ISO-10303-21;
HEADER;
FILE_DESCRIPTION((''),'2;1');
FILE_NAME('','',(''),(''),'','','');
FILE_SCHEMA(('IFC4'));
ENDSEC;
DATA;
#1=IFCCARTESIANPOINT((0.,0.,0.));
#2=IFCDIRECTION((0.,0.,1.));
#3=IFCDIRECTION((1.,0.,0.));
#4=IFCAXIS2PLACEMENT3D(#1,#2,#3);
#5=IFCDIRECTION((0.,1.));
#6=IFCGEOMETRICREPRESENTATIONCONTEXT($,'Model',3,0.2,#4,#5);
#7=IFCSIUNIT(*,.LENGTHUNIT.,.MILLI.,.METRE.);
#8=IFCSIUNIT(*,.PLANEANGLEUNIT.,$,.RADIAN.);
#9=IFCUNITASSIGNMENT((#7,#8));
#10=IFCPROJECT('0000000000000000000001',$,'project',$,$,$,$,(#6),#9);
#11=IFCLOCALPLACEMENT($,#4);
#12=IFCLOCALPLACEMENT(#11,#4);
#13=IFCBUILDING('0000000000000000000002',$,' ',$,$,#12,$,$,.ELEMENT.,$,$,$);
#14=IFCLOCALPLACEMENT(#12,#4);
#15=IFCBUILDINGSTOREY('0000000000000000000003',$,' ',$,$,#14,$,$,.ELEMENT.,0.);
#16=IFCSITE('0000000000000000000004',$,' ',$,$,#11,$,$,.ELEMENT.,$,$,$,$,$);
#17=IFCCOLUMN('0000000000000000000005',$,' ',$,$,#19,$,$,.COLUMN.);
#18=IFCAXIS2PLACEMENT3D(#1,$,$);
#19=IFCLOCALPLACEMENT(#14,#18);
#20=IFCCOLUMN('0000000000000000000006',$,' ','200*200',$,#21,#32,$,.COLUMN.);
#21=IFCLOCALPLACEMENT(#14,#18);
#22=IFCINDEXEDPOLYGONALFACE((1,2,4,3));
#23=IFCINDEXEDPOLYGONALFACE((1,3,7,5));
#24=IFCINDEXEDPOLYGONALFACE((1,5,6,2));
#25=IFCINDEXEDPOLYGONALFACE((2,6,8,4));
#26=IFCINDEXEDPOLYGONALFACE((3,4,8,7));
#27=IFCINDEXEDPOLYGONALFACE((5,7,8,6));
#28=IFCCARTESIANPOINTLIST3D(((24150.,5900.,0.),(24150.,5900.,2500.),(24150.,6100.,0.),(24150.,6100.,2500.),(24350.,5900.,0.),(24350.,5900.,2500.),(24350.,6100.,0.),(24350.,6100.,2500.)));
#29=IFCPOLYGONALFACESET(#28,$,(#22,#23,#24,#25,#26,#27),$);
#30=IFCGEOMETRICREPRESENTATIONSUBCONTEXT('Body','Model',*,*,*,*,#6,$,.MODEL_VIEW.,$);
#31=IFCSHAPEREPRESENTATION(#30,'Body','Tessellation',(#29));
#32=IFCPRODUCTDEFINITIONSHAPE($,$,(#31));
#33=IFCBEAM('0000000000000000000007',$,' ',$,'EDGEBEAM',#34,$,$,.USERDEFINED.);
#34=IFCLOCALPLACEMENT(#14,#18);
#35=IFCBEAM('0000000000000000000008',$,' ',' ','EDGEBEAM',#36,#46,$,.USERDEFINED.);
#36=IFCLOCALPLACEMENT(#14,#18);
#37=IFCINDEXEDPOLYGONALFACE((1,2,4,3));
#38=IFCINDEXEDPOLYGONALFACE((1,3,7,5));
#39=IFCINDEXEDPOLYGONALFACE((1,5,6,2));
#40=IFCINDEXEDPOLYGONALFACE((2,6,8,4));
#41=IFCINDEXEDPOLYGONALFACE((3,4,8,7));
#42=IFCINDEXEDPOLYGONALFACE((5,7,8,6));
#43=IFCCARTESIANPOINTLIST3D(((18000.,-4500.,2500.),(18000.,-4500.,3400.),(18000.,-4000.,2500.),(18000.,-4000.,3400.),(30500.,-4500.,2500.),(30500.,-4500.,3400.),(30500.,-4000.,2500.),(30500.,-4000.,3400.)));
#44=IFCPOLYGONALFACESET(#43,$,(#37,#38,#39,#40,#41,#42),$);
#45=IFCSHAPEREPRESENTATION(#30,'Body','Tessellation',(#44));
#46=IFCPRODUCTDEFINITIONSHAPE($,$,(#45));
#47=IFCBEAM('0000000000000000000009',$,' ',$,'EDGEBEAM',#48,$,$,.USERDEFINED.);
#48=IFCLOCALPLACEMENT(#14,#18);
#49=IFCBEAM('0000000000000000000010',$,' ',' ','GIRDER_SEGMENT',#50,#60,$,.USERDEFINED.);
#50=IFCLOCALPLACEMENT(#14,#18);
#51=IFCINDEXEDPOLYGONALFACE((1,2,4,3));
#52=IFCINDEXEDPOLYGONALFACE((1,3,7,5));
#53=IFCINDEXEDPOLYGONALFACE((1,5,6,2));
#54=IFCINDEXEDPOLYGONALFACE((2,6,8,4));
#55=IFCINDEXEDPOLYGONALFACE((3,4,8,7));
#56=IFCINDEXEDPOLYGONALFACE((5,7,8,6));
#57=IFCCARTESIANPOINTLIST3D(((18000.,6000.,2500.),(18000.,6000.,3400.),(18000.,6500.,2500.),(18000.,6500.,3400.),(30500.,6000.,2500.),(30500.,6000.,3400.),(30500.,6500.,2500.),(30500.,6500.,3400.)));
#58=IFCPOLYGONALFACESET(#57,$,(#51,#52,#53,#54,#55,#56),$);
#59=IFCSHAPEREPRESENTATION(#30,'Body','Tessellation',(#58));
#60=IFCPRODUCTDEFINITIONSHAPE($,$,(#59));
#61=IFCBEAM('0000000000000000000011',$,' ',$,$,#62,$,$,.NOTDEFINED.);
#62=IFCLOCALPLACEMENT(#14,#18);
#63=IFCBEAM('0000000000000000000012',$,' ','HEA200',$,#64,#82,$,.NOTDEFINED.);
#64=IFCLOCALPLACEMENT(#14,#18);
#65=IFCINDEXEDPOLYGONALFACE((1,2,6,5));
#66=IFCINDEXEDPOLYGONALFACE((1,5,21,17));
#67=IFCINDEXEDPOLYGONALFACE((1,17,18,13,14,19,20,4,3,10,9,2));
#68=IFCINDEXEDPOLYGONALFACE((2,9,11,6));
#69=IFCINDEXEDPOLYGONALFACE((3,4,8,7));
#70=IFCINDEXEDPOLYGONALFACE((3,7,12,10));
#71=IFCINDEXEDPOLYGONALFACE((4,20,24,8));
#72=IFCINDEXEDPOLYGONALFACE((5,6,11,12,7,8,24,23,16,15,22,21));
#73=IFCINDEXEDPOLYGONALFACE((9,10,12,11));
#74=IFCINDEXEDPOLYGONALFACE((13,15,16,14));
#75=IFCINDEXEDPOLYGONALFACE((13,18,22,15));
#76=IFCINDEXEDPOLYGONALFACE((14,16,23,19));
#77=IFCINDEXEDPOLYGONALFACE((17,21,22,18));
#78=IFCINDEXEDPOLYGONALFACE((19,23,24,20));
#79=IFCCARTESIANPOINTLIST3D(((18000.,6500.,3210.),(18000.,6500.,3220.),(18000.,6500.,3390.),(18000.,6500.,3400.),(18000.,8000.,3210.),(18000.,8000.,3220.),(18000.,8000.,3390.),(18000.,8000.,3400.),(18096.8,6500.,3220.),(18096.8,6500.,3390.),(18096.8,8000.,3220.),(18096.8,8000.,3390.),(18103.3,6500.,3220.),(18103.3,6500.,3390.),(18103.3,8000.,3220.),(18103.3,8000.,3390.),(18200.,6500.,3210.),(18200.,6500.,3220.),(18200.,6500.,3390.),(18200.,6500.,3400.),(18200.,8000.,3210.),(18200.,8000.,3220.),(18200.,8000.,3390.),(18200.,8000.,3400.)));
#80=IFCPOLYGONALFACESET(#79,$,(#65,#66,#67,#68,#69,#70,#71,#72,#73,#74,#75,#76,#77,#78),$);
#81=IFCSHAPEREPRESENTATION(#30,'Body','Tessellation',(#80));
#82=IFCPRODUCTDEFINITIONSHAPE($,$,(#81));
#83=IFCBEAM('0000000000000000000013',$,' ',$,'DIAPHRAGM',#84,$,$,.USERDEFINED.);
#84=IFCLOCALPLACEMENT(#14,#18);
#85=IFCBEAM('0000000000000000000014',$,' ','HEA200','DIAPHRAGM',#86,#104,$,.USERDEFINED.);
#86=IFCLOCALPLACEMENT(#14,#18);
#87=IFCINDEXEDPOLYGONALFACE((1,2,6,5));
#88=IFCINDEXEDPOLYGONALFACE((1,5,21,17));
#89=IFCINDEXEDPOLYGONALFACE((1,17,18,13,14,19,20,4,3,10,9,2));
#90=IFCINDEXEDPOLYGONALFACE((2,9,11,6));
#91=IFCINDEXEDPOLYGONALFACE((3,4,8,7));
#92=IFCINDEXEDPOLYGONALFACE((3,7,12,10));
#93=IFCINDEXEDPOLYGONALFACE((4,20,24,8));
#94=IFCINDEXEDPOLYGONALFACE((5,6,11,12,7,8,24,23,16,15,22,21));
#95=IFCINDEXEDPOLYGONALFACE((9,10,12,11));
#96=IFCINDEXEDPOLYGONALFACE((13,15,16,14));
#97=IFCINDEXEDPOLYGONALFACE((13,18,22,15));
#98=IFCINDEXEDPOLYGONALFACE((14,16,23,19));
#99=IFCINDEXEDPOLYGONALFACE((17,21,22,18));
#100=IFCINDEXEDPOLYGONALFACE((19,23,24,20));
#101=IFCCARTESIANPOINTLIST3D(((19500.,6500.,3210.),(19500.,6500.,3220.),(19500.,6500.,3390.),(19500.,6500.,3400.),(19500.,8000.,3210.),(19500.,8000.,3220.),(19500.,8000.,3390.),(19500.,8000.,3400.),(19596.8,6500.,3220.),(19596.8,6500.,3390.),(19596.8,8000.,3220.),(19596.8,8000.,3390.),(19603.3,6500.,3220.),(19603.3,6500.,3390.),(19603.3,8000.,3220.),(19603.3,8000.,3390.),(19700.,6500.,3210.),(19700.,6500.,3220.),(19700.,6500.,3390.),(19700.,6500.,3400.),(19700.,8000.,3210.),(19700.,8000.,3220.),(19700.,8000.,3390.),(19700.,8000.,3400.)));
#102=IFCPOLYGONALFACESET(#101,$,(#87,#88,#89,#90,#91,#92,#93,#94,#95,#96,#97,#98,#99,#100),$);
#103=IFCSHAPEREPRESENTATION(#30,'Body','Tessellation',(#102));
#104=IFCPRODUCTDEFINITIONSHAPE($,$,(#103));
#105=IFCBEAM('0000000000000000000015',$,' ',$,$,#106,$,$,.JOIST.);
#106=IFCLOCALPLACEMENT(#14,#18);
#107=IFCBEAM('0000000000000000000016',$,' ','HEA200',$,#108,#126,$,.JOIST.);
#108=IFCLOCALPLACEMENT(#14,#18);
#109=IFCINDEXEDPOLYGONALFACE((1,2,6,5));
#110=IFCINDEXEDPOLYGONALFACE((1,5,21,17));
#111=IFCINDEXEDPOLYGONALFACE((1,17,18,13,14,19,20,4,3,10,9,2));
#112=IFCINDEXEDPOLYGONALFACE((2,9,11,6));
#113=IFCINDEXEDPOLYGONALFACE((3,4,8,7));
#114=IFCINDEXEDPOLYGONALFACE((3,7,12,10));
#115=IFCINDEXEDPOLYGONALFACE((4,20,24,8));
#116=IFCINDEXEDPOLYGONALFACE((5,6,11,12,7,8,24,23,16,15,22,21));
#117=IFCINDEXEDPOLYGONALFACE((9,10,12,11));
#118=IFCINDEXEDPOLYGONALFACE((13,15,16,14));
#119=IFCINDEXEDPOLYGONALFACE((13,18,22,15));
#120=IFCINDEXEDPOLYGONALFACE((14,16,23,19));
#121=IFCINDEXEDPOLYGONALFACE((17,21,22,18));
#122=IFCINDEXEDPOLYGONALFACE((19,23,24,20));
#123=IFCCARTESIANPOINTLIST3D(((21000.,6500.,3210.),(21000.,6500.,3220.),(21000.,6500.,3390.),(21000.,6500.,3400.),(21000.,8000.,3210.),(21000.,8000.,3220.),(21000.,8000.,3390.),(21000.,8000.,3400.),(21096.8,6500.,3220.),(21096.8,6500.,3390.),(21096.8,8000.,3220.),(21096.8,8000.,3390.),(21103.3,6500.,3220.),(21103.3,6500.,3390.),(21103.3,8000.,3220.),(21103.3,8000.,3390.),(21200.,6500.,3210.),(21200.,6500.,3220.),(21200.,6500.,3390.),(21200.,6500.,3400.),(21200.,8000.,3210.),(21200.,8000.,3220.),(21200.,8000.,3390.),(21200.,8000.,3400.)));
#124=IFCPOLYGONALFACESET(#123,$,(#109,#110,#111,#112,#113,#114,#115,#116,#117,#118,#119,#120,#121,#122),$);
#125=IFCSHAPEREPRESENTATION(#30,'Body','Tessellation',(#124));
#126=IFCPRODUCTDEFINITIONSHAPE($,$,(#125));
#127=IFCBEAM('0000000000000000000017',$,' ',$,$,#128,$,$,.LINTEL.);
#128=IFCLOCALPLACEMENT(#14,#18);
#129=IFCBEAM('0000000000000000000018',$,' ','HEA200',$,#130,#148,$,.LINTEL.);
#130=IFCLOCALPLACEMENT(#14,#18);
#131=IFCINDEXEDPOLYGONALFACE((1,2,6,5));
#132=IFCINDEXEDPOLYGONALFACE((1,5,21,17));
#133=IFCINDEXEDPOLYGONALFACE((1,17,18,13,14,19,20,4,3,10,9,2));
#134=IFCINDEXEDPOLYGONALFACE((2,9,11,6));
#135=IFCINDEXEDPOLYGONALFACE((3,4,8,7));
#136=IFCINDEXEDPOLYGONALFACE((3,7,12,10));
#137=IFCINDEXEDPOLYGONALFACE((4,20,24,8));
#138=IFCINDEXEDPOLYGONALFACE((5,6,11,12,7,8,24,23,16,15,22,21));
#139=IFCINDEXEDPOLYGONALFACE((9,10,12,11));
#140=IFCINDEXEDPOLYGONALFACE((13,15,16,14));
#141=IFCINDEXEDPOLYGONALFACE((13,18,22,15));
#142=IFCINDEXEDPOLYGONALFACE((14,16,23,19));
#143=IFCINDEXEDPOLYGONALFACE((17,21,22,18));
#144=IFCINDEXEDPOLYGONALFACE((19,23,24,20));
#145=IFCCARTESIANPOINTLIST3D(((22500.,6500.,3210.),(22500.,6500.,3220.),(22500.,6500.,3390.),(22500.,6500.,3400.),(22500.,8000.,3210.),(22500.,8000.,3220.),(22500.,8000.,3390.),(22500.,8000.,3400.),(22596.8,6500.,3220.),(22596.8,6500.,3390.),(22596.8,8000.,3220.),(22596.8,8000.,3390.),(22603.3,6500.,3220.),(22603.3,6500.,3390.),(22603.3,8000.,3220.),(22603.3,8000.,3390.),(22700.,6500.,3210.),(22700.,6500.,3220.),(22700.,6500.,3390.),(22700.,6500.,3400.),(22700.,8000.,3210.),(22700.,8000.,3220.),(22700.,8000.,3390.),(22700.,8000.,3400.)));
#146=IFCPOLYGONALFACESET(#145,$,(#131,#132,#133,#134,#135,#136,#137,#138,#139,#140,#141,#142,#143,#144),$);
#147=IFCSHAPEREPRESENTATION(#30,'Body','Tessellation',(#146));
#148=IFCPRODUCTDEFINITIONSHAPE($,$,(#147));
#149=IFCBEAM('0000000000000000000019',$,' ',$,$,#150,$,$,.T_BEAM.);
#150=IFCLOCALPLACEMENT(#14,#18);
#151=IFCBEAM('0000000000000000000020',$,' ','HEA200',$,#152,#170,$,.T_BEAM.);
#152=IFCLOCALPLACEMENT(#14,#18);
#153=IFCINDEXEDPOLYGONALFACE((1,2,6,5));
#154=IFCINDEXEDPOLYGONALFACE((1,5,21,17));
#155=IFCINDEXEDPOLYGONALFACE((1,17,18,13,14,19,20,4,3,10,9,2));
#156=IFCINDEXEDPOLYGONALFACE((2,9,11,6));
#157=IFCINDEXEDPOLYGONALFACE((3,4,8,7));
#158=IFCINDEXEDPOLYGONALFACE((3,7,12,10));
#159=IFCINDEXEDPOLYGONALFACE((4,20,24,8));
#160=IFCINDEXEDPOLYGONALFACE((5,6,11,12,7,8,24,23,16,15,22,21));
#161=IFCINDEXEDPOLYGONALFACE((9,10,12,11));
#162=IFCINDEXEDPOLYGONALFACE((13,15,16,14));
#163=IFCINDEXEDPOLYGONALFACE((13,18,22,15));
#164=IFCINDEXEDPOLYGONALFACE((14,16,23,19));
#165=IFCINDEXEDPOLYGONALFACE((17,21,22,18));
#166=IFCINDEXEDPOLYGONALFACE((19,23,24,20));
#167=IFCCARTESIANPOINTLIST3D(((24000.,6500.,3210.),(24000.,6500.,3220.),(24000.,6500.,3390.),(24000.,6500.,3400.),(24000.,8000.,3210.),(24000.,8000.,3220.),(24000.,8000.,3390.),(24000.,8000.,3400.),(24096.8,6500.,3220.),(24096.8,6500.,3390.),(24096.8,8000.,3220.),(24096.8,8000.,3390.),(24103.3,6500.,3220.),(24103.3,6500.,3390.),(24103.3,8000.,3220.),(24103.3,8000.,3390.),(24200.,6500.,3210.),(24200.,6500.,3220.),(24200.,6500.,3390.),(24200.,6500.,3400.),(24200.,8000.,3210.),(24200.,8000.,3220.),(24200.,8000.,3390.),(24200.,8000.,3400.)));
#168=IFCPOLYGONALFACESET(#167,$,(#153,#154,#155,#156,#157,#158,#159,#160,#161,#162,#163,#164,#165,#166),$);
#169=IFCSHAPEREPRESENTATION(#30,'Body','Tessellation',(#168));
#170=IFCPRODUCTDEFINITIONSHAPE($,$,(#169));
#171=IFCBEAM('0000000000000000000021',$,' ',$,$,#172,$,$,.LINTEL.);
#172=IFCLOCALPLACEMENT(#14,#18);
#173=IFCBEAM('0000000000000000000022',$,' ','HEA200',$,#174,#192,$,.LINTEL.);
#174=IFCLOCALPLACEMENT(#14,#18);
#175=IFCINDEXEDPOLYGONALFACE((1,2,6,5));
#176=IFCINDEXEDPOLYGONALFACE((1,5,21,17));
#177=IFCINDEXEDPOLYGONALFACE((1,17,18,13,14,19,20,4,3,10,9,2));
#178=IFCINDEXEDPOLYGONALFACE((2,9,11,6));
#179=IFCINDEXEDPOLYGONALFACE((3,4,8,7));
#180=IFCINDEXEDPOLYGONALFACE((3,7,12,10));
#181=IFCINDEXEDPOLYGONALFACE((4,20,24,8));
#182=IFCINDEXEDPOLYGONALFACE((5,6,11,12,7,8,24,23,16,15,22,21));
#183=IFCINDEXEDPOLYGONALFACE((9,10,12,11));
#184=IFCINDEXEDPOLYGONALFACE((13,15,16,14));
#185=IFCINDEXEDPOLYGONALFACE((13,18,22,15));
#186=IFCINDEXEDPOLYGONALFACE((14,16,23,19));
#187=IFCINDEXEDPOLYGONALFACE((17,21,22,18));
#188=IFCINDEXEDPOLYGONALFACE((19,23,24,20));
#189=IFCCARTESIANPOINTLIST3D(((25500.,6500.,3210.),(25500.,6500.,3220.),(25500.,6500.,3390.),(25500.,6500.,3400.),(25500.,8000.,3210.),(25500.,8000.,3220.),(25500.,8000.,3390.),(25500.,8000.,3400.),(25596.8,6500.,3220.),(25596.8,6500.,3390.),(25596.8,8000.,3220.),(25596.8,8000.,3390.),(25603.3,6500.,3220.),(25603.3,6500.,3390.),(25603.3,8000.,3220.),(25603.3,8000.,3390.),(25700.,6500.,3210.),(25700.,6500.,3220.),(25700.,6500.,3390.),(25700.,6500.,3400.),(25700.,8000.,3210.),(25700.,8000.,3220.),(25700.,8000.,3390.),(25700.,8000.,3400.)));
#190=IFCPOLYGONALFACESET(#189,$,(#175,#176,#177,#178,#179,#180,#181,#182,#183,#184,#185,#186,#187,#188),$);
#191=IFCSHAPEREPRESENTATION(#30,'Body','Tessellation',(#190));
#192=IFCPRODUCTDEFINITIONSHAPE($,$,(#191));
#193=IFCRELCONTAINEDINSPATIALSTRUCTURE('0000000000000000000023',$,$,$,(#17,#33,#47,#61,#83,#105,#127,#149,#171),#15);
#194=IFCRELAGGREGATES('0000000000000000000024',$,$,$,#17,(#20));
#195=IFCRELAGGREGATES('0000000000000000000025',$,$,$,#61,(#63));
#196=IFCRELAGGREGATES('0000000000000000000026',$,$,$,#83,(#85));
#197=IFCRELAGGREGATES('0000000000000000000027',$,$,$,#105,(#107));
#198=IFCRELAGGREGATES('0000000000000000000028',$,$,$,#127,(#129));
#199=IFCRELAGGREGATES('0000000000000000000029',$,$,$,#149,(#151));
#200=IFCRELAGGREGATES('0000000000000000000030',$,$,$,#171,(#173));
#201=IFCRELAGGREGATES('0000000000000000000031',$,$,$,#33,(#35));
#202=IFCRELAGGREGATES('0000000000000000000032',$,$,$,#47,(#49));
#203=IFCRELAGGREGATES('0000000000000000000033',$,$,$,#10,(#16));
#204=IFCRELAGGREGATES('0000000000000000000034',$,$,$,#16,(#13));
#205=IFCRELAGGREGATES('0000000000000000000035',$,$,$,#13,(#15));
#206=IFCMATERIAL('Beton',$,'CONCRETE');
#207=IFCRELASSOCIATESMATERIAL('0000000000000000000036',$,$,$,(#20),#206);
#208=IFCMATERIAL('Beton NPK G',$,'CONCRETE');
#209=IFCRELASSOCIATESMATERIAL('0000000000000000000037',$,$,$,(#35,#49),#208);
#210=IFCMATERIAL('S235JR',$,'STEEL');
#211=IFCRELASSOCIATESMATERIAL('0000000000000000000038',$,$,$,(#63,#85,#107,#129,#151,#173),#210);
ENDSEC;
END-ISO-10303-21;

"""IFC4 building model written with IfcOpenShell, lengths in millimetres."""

from ifc_helpers import new_model, si_unit, direction, frame, origin_with_axes, place, context, subcontext, project, spatial, line, indexed_curve, outline, extrude, material, element, aggregate, save


model = new_model("IFC4")

# Units and contexts
model_context = context("Model", 3, precision=0.2, world=origin_with_axes(), true_north=direction((0.0, 1.0)))
body_context = subcontext(model_context, "Body", "Model", "MODEL_VIEW")
ifc_project = project(units=[si_unit("LENGTHUNIT", "METRE", prefix="MILLI"), si_unit("PLANEANGLEUNIT", "RADIAN")], contexts=[model_context])

# Site, building, storey
site_placement = place(None, origin_with_axes())
site = spatial("IfcSite", under=ifc_project, at=site_placement, Name=" ", CompositionType="ELEMENT")
building_placement = place(site_placement, origin_with_axes())
building = spatial("IfcBuilding", under=site, at=building_placement, Name=" ", CompositionType="ELEMENT")
storey_placement = place(building_placement, origin_with_axes())
storey = spatial("IfcBuildingStorey", under=building, at=storey_placement, Name=" ", CompositionType="ELEMENT", Elevation=0.0)

# Columns
column_1_placement = place(storey_placement, frame((24250.0, 6000.0, 0.0), z_axis=(-1.0, 0.0, 0.0), x_axis=(0.0, 0.0, 1.0)))
column_1 = element("IfcColumn", 1, at=column_1_placement, inside=storey, Name=" ", PredefinedType="COLUMN")
ifc_material_1 = material(Name="Beton", Category="CONCRETE")
column_2_placement = place(column_1_placement, origin_with_axes())
column_2 = element("IfcColumn", 2, at=column_2_placement, material=ifc_material_1, Name=" ", Description="200*200", PredefinedType="COLUMN", context=body_context, shape_type="SolidModel", body=[
    extrude(outline(indexed_curve([(-100.0, -100.0), (100.0, -100.0), (100.0, 100.0), (-100.0, 100.0)], segments=[line(1, 2, 3, 4, 1)])), frame((0.0, 0.0, 0.0), z_axis=(-1.0, 0.0, 0.0), x_axis=(0.0, 0.0, 1.0)), (0.0, 0.0, -1.0), 2500.0),
])
aggregate(column_1, [column_2])

# Beams
beam_1_placement = place(storey_placement, frame((30500.0, -4250.0, 2950.0), z_axis=(0.0, 1.0, 0.0), x_axis=(-1.0, 0.0, 0.0)))
beam_1 = element("IfcBeam", 3, at=beam_1_placement, inside=storey, Name=" ", ObjectType="EDGEBEAM", PredefinedType="USERDEFINED")
ifc_material_2 = material(Name="Beton NPK G", Category="CONCRETE")
beam_2_placement = place(beam_1_placement, origin_with_axes())
beam_2 = element("IfcBeam", 4, at=beam_2_placement, material=ifc_material_2, Name=" ", Description=" ", ObjectType="EDGEBEAM", PredefinedType="USERDEFINED", context=body_context, shape_type="SolidModel", body=[
    extrude(outline(indexed_curve([(-250.0, -450.0), (250.0, -450.0), (250.0, 450.0), (-250.0, 450.0)], segments=[line(1, 2, 3, 4, 1)])), frame((0.0, 0.0, 0.0), z_axis=(-1.0, 0.0, 0.0), x_axis=(0.0, 0.0, 1.0)), (0.0, 0.0, -1.0), 12500.0),
])
beam_3_placement = place(storey_placement, frame((30500.0, 6250.0, 2950.0), z_axis=(0.0, 1.0, 0.0), x_axis=(-1.0, 0.0, 0.0)))
beam_3 = element("IfcBeam", 5, at=beam_3_placement, inside=storey, Name=" ", ObjectType="EDGEBEAM", PredefinedType="USERDEFINED")
beam_4_placement = place(beam_3_placement, origin_with_axes())
beam_4 = element("IfcBeam", 6, at=beam_4_placement, material=ifc_material_2, Name=" ", Description=" ", ObjectType="GIRDER_SEGMENT", PredefinedType="USERDEFINED", context=body_context, shape_type="SolidModel", body=[
    extrude(outline(indexed_curve([(-250.0, -450.0), (250.0, -450.0), (250.0, 450.0), (-250.0, 450.0)], segments=[line(1, 2, 3, 4, 1)])), frame((0.0, 0.0, 0.0), z_axis=(-1.0, 0.0, 0.0), x_axis=(0.0, 0.0, 1.0)), (0.0, 0.0, -1.0), 12500.0),
])
beam_5_placement = place(storey_placement, frame((18100.0, 6500.0, 3305.0), z_axis=(1.0, 0.0, 0.0), x_axis=(0.0, 1.0, 0.0)))
beam_5 = element("IfcBeam", 7, at=beam_5_placement, inside=storey, Name=" ", PredefinedType="NOTDEFINED")
ifc_material_3 = material(Name="S235JR", Category="STEEL")
beam_6_placement = place(beam_5_placement, origin_with_axes())
beam_6 = element("IfcBeam", 8, at=beam_6_placement, material=ifc_material_3, Name=" ", Description="HEA200", PredefinedType="NOTDEFINED", context=body_context, shape_type="SolidModel", body=[
    extrude(outline(indexed_curve([(-100.0, -95.0), (100.0, -95.0), (100.0, -85.0), (3.2, -85.0), (3.2, 85.0), (100.0, 85.0), (100.0, 95.0), (-100.0, 95.0), (-100.0, 85.0), (-3.2, 85.0), (-3.2, -85.0), (-100.0, -85.0)], segments=[line(1, 2, 3, 4, 5, 6, 7, 8, 9, 10, 11, 12, 1)])), frame((0.0, 0.0, 0.0), z_axis=(-1.0, 0.0, 0.0), x_axis=(0.0, 0.0, 1.0)), (0.0, 0.0, -1.0), 1500.0),
])
aggregate(beam_5, [beam_6])
beam_7_placement = place(storey_placement, frame((19600.0, 6500.0, 3305.0), z_axis=(1.0, 0.0, 0.0), x_axis=(0.0, 1.0, 0.0)))
beam_7 = element("IfcBeam", 9, at=beam_7_placement, inside=storey, Name=" ", ObjectType="DIAPHRAGM", PredefinedType="USERDEFINED")
beam_8_placement = place(beam_7_placement, origin_with_axes())
beam_8 = element("IfcBeam", 10, at=beam_8_placement, material=ifc_material_3, Name=" ", Description="HEA200", ObjectType="DIAPHRAGM", PredefinedType="USERDEFINED", context=body_context, shape_type="SolidModel", body=[
    extrude(outline(indexed_curve([(-100.0, -95.0), (100.0, -95.0), (100.0, -85.0), (3.2, -85.0), (3.2, 85.0), (100.0, 85.0), (100.0, 95.0), (-100.0, 95.0), (-100.0, 85.0), (-3.2, 85.0), (-3.2, -85.0), (-100.0, -85.0)], segments=[line(1, 2, 3, 4, 5, 6, 7, 8, 9, 10, 11, 12, 1)])), frame((0.0, 0.0, 0.0), z_axis=(-1.0, 0.0, 0.0), x_axis=(0.0, 0.0, 1.0)), (0.0, 0.0, -1.0), 1500.0),
])
aggregate(beam_7, [beam_8])
beam_9_placement = place(storey_placement, frame((21100.0, 6500.0, 3305.0), z_axis=(1.0, 0.0, 0.0), x_axis=(0.0, 1.0, 0.0)))
beam_9 = element("IfcBeam", 11, at=beam_9_placement, inside=storey, Name=" ", PredefinedType="JOIST")
beam_10_placement = place(beam_9_placement, origin_with_axes())
beam_10 = element("IfcBeam", 12, at=beam_10_placement, material=ifc_material_3, Name=" ", Description="HEA200", PredefinedType="JOIST", context=body_context, shape_type="SolidModel", body=[
    extrude(outline(indexed_curve([(-100.0, -95.0), (100.0, -95.0), (100.0, -85.0), (3.2, -85.0), (3.2, 85.0), (100.0, 85.0), (100.0, 95.0), (-100.0, 95.0), (-100.0, 85.0), (-3.2, 85.0), (-3.2, -85.0), (-100.0, -85.0)], segments=[line(1, 2, 3, 4, 5, 6, 7, 8, 9, 10, 11, 12, 1)])), frame((0.0, 0.0, 0.0), z_axis=(-1.0, 0.0, 0.0), x_axis=(0.0, 0.0, 1.0)), (0.0, 0.0, -1.0), 1500.0),
])
aggregate(beam_9, [beam_10])
beam_11_placement = place(storey_placement, frame((22600.0, 6500.0, 3305.0), z_axis=(1.0, 0.0, 0.0), x_axis=(0.0, 1.0, 0.0)))
beam_11 = element("IfcBeam", 13, at=beam_11_placement, inside=storey, Name=" ", PredefinedType="LINTEL")
beam_12_placement = place(beam_11_placement, origin_with_axes())
beam_12 = element("IfcBeam", 14, at=beam_12_placement, material=ifc_material_3, Name=" ", Description="HEA200", PredefinedType="LINTEL", context=body_context, shape_type="SolidModel", body=[
    extrude(outline(indexed_curve([(-100.0, -95.0), (100.0, -95.0), (100.0, -85.0), (3.2, -85.0), (3.2, 85.0), (100.0, 85.0), (100.0, 95.0), (-100.0, 95.0), (-100.0, 85.0), (-3.2, 85.0), (-3.2, -85.0), (-100.0, -85.0)], segments=[line(1, 2, 3, 4, 5, 6, 7, 8, 9, 10, 11, 12, 1)])), frame((0.0, 0.0, 0.0), z_axis=(-1.0, 0.0, 0.0), x_axis=(0.0, 0.0, 1.0)), (0.0, 0.0, -1.0), 1500.0),
])
aggregate(beam_11, [beam_12])
beam_13_placement = place(storey_placement, frame((24100.0, 6500.0, 3305.0), z_axis=(1.0, 0.0, 0.0), x_axis=(0.0, 1.0, 0.0)))
beam_13 = element("IfcBeam", 15, at=beam_13_placement, inside=storey, Name=" ", PredefinedType="T_BEAM")
beam_14_placement = place(beam_13_placement, origin_with_axes())
beam_14 = element("IfcBeam", 16, at=beam_14_placement, material=ifc_material_3, Name=" ", Description="HEA200", PredefinedType="T_BEAM", context=body_context, shape_type="SolidModel", body=[
    extrude(outline(indexed_curve([(-100.0, -95.0), (100.0, -95.0), (100.0, -85.0), (3.2, -85.0), (3.2, 85.0), (100.0, 85.0), (100.0, 95.0), (-100.0, 95.0), (-100.0, 85.0), (-3.2, 85.0), (-3.2, -85.0), (-100.0, -85.0)], segments=[line(1, 2, 3, 4, 5, 6, 7, 8, 9, 10, 11, 12, 1)])), frame((0.0, 0.0, 0.0), z_axis=(-1.0, 0.0, 0.0), x_axis=(0.0, 0.0, 1.0)), (0.0, 0.0, -1.0), 1500.0),
])
aggregate(beam_13, [beam_14])
beam_15_placement = place(storey_placement, frame((25600.0, 6500.0, 3305.0), z_axis=(1.0, 0.0, 0.0), x_axis=(0.0, 1.0, 0.0)))
beam_15 = element("IfcBeam", 17, at=beam_15_placement, inside=storey, Name=" ", PredefinedType="LINTEL")
beam_16_placement = place(beam_15_placement, origin_with_axes())
beam_16 = element("IfcBeam", 18, at=beam_16_placement, material=ifc_material_3, Name=" ", Description="HEA200", PredefinedType="LINTEL", context=body_context, shape_type="SolidModel", body=[
    extrude(outline(indexed_curve([(-100.0, -95.0), (100.0, -95.0), (100.0, -85.0), (3.2, -85.0), (3.2, 85.0), (100.0, 85.0), (100.0, 95.0), (-100.0, 95.0), (-100.0, 85.0), (-3.2, 85.0), (-3.2, -85.0), (-100.0, -85.0)], segments=[line(1, 2, 3, 4, 5, 6, 7, 8, 9, 10, 11, 12, 1)])), frame((0.0, 0.0, 0.0), z_axis=(-1.0, 0.0, 0.0), x_axis=(0.0, 0.0, 1.0)), (0.0, 0.0, -1.0), 1500.0),
])
aggregate(beam_15, [beam_16])

aggregate(beam_1, [beam_2])
aggregate(beam_3, [beam_4])

save(model, "model.ifc")
